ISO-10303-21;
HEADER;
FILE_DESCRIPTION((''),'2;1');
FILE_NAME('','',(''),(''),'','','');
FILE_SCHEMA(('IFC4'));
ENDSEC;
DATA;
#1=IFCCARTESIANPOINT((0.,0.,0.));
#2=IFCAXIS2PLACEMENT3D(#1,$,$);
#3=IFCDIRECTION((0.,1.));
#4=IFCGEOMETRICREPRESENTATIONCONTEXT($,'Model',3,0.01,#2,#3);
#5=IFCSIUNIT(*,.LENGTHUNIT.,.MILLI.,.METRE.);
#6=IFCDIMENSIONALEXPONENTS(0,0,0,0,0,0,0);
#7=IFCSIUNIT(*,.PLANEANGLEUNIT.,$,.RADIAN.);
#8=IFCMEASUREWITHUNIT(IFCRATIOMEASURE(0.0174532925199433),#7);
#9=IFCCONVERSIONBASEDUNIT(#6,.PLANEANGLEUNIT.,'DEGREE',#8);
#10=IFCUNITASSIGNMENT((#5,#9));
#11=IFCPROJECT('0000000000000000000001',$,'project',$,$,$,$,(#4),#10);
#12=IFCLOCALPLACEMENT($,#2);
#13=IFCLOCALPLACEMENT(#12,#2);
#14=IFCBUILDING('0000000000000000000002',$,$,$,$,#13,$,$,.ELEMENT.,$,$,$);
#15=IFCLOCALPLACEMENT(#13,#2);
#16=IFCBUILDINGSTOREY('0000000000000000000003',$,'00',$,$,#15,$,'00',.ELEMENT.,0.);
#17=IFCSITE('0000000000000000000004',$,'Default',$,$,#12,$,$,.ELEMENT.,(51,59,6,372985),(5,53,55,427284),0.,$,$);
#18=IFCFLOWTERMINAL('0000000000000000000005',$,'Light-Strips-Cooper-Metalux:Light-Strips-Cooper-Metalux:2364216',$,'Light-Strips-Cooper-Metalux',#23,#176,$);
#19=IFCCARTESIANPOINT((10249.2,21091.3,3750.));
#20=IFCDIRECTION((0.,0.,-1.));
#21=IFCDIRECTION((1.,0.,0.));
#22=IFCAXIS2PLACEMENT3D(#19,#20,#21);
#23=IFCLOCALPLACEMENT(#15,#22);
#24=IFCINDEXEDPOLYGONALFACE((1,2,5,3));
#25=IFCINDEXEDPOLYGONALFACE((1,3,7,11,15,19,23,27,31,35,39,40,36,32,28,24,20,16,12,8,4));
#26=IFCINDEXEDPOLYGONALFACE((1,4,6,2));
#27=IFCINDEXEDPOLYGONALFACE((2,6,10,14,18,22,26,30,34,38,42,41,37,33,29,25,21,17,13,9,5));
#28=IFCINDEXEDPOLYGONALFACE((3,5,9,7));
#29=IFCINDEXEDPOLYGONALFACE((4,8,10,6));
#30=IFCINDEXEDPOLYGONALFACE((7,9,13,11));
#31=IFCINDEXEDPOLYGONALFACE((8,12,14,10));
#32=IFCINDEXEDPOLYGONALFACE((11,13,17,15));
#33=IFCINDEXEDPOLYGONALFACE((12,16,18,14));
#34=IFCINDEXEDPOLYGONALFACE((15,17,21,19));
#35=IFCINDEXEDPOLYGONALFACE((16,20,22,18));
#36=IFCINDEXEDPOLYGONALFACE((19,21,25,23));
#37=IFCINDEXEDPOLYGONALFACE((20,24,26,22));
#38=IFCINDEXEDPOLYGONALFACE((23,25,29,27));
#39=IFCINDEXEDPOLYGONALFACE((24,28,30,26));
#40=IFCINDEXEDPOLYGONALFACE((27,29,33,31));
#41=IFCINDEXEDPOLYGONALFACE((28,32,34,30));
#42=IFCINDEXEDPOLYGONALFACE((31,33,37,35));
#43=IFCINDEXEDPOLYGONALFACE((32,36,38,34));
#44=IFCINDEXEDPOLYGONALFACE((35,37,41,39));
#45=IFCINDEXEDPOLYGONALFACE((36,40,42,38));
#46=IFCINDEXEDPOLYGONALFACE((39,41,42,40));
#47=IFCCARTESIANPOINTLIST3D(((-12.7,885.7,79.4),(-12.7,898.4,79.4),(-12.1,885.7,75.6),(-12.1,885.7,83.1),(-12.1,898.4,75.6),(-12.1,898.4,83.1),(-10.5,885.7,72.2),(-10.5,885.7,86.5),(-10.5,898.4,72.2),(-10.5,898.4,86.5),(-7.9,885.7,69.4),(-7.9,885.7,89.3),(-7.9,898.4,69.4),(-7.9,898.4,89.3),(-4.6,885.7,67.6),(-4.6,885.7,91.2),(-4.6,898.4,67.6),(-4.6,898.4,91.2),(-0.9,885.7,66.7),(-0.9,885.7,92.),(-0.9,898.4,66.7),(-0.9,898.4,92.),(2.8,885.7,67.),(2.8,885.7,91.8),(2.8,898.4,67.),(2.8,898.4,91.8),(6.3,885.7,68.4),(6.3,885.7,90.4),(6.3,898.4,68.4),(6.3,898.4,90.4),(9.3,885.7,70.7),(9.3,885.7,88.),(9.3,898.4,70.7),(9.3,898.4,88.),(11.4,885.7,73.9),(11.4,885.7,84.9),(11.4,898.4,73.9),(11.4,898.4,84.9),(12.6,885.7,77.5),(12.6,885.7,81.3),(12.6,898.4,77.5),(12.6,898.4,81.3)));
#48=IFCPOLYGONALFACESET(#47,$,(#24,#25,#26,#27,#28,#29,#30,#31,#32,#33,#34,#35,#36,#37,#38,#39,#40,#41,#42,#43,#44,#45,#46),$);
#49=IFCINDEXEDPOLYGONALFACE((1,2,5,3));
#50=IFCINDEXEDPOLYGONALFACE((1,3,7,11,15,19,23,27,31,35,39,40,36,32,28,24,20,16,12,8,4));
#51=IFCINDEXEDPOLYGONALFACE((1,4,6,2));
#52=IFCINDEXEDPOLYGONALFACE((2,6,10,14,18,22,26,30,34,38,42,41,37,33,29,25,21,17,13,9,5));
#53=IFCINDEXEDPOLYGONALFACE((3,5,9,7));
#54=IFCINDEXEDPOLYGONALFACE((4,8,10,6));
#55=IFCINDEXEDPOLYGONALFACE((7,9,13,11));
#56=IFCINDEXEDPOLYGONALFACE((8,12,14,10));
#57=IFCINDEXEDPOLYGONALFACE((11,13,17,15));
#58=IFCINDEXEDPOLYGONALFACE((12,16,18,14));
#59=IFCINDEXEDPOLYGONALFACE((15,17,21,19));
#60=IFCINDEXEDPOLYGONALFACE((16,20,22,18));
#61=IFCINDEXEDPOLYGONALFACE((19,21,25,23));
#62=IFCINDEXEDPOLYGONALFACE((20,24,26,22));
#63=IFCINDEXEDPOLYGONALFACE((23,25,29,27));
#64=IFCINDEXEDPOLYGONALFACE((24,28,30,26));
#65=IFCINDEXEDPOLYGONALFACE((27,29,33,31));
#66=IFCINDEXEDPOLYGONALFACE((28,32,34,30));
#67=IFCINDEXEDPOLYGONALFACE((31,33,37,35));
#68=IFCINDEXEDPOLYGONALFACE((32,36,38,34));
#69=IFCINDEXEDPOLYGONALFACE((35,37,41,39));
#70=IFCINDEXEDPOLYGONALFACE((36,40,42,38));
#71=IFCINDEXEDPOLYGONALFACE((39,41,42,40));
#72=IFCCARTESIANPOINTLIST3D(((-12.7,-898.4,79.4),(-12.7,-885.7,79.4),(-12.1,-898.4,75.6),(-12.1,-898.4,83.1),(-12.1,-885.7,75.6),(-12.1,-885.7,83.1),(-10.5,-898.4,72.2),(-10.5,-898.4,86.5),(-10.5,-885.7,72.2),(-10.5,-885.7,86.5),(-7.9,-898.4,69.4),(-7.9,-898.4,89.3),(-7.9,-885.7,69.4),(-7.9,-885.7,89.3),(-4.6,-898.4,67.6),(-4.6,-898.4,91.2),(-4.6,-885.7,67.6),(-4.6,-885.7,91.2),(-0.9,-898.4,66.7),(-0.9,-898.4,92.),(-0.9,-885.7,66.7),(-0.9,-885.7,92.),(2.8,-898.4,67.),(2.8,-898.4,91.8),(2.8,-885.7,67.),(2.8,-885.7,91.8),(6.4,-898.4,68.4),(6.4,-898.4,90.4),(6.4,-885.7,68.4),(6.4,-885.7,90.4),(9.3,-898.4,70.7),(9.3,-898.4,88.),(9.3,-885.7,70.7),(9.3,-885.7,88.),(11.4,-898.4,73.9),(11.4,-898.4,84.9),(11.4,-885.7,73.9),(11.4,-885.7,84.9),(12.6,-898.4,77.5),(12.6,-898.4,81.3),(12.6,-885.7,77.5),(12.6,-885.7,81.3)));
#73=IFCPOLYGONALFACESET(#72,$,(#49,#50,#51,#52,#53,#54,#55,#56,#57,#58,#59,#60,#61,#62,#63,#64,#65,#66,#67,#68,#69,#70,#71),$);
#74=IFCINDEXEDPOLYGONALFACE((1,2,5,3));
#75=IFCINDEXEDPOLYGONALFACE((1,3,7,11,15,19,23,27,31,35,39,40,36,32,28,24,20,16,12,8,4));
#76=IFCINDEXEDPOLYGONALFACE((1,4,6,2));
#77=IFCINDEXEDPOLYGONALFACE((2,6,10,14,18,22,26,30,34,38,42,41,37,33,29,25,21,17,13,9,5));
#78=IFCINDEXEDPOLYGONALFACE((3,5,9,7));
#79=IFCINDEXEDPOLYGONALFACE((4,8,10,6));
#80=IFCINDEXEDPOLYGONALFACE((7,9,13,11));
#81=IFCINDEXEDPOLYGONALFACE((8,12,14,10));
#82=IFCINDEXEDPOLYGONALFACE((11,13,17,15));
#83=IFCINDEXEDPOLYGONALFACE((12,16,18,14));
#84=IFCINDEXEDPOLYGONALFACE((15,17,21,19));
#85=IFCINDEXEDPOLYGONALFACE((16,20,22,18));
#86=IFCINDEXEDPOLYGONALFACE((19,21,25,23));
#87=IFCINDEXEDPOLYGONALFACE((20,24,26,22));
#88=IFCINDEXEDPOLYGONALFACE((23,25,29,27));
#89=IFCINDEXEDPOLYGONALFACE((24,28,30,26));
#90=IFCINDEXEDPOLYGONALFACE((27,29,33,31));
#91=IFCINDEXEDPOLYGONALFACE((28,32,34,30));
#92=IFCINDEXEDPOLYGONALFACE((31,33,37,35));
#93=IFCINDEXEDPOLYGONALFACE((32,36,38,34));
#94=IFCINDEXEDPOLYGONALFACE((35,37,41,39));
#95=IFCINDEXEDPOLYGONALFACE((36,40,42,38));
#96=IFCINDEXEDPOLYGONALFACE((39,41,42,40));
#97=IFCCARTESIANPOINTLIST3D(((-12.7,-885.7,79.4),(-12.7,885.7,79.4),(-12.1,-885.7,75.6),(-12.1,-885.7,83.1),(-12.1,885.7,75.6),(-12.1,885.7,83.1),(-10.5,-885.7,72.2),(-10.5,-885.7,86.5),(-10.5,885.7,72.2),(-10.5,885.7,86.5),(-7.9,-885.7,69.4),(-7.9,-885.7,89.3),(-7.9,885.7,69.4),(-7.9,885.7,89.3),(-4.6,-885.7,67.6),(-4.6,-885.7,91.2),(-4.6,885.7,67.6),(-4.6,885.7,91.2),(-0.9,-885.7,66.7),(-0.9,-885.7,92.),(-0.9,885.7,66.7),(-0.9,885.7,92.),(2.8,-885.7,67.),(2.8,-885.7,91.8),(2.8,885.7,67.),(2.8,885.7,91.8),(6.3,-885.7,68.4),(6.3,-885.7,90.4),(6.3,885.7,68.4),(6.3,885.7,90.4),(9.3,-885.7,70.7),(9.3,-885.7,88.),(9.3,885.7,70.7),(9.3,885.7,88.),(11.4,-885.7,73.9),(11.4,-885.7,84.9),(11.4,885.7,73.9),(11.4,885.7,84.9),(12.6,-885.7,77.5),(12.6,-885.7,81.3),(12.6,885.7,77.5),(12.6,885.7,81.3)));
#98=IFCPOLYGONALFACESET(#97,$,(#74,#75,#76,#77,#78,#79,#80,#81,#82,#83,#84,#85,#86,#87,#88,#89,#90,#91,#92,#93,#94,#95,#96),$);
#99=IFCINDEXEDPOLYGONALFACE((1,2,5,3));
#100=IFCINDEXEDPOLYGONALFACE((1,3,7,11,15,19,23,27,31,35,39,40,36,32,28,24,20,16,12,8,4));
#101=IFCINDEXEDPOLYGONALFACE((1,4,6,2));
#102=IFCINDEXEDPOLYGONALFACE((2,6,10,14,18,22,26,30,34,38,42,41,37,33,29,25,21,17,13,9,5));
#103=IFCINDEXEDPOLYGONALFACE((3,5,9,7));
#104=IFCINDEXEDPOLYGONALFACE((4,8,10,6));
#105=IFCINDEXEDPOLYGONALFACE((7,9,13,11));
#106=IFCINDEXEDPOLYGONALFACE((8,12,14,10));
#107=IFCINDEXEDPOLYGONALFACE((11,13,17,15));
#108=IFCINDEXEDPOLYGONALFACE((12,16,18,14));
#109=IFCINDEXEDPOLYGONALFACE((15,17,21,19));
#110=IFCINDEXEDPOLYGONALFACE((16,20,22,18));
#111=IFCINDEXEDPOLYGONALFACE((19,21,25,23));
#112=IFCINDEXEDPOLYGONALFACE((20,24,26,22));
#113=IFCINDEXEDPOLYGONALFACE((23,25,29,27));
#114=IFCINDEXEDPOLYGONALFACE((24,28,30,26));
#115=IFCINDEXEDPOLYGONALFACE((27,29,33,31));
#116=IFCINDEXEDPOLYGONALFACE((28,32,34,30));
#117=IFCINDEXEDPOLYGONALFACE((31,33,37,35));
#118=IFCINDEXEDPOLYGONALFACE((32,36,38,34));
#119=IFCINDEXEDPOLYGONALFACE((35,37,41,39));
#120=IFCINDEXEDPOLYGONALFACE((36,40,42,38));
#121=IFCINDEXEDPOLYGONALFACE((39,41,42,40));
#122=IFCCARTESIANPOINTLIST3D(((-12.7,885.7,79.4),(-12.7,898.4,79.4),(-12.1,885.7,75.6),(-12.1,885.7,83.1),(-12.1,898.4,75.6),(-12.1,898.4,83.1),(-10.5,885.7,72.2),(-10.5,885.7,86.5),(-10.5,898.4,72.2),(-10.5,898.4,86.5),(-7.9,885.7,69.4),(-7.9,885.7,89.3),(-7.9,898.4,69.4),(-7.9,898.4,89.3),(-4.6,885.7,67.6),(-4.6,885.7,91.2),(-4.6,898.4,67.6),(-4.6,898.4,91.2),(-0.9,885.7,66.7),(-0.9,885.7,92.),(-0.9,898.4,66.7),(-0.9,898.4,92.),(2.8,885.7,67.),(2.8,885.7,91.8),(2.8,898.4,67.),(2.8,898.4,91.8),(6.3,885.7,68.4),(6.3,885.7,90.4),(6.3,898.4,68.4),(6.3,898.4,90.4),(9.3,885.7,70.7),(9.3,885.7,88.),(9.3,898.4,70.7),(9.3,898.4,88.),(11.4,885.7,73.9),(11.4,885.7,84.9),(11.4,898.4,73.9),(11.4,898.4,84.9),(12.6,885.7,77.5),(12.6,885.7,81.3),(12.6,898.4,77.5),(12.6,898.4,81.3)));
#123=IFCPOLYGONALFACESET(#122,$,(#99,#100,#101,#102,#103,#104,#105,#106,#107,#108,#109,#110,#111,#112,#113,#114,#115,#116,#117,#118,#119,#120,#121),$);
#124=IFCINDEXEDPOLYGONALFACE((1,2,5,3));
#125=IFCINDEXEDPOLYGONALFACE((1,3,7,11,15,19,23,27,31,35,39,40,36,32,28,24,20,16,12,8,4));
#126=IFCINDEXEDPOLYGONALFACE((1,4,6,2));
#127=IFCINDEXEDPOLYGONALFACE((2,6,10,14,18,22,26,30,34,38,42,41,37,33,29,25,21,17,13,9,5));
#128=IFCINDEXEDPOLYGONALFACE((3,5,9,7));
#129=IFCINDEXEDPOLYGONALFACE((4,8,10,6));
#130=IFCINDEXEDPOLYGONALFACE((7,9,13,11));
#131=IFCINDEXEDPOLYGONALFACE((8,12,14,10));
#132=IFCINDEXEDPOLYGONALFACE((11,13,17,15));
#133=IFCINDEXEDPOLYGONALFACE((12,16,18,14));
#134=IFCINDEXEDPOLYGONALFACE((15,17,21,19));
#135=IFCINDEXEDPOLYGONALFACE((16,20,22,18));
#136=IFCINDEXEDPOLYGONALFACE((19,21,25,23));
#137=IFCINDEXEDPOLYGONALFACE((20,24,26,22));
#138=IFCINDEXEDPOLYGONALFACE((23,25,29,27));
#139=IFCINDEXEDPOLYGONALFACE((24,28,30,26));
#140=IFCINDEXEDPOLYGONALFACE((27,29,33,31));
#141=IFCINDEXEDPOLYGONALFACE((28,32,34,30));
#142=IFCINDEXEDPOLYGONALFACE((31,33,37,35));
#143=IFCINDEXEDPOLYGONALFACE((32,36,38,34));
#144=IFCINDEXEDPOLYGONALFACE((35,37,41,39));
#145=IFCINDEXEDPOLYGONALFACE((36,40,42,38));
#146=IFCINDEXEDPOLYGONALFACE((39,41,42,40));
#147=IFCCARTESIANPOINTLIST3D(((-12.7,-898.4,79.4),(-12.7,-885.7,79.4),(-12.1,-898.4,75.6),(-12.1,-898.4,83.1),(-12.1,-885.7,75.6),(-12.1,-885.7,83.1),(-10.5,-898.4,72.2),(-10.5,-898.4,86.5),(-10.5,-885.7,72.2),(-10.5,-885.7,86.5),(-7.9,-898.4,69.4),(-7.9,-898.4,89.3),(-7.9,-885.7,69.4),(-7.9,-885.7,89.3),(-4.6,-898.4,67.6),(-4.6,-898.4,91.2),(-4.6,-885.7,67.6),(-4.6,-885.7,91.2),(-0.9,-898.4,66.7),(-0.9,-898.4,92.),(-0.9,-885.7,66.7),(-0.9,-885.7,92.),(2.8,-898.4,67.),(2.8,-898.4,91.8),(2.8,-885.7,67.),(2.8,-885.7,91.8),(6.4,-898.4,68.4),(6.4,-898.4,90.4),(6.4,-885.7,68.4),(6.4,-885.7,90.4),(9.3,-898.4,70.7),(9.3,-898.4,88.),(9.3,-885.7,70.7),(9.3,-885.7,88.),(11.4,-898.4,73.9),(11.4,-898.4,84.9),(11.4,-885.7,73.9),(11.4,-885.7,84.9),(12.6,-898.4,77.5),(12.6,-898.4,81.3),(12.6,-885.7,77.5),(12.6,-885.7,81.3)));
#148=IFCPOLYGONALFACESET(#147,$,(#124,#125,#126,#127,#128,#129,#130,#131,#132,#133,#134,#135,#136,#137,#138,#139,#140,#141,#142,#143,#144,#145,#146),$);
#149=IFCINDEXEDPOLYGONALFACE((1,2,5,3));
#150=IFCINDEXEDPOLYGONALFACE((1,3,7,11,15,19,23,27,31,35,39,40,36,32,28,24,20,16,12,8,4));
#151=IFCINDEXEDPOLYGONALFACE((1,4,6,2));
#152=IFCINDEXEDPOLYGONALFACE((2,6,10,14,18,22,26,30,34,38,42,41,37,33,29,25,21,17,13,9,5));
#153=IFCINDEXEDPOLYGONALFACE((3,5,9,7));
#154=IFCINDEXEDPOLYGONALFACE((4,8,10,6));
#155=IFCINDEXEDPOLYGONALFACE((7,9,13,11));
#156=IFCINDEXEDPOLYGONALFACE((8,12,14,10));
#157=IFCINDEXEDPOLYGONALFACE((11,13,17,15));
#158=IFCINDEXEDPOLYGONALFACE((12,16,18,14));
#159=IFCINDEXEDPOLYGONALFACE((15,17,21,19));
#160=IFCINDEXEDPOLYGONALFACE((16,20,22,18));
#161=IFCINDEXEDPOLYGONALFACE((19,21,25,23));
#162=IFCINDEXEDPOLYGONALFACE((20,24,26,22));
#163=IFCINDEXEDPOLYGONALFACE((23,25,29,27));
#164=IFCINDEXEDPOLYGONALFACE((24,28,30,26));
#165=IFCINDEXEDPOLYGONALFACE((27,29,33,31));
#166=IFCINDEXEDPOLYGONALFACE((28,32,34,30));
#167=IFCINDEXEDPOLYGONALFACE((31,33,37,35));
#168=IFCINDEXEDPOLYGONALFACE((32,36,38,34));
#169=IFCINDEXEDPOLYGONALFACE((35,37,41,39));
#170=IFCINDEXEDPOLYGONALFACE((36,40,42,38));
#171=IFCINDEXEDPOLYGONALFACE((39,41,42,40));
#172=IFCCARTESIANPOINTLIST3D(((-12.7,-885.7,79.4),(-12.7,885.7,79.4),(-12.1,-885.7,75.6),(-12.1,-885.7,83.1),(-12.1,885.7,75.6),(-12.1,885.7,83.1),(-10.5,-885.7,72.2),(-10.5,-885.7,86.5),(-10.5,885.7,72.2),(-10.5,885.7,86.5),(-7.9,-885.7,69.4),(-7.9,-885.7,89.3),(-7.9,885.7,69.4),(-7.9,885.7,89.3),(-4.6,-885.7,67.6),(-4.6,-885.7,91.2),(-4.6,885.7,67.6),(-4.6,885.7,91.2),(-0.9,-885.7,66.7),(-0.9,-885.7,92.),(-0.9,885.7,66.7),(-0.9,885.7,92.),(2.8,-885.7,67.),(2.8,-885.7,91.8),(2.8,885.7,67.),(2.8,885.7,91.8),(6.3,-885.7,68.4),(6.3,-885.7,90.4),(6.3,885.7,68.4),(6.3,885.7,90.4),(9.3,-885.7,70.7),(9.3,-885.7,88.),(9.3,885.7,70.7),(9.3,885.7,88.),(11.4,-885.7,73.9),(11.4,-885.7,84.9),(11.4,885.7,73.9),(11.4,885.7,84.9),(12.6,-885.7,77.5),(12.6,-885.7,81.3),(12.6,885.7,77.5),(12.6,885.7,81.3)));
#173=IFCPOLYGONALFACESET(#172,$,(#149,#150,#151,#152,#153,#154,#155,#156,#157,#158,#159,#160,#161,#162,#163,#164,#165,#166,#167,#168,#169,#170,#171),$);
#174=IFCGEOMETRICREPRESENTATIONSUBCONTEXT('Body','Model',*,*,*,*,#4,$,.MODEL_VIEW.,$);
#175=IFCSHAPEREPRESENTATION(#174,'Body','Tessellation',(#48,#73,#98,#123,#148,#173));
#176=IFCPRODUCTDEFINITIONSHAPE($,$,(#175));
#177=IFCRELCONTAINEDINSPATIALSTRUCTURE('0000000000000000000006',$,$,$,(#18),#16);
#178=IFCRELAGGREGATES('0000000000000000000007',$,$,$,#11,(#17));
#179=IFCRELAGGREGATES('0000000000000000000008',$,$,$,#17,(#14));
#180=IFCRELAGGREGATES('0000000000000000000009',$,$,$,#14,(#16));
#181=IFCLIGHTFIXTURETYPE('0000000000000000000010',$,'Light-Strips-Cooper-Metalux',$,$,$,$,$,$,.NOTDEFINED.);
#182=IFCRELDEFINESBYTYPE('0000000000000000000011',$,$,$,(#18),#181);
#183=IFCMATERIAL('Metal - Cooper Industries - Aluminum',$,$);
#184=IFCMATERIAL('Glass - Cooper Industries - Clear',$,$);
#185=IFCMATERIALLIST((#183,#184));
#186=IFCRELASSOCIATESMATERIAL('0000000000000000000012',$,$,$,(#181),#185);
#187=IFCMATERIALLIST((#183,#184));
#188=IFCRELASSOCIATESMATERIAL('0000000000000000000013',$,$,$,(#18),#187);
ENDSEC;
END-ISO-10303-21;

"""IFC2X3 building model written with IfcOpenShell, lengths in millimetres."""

from ifc_helpers import new_model, entity, si_unit, converted_unit, direction, frame, frame_2d, origin, place, context, subcontext, project, spatial, circle, extrude, source, transform, mapped, material, material_list, type_object, type_shapes, element, save


model = new_model("IFC2X3")

# Units and contexts
model_context = context("Model", 3, precision=0.01, world=origin(), true_north=direction((0.0, 1.0)))
body_context = subcontext(model_context, "Body", "Model", "MODEL_VIEW")
ifc_project = project(units=[si_unit("LENGTHUNIT", "METRE", prefix="MILLI"), converted_unit("PLANEANGLEUNIT", "DEGREE", entity("IfcRatioMeasure", 0.0174532925199433), si_unit("PLANEANGLEUNIT", "RADIAN"), dimensions=[0, 0, 0, 0, 0, 0, 0])], contexts=[model_context])

# Site, building, storey
site_placement = place(None, origin())
site = spatial("IfcSite", under=ifc_project, at=site_placement, Name="Default", CompositionType="ELEMENT", RefLatitude=(51, 59, 6, 372985), RefLongitude=(5, 53, 55, 427284), RefElevation=0.0)
building_placement = place(site_placement, origin())
building = spatial("IfcBuilding", under=site, at=building_placement, CompositionType="ELEMENT")
storey_placement = place(building_placement, origin())
storey = spatial("IfcBuildingStorey", under=building, at=storey_placement, Name="00", LongName="00", CompositionType="ELEMENT", Elevation=0.0)

# Flow terminal
ifc_material_1 = material(Name="Metal - Cooper Industries - Aluminum")
ifc_material_2 = material(Name="Glass - Cooper Industries - Clear")
ifc_material_list_1 = material_list([ifc_material_1, ifc_material_2])
ifc_material_list_2 = material_list([ifc_material_1, ifc_material_2])
light_fixture_type_1 = type_object("IfcLightFixtureType", Name="Light-Strips-Cooper-Metalux", PredefinedType="NOTDEFINED", material=ifc_material_list_2)
shared_shape_1 = source(origin(), body_context, "Body", "SweptSolid", [
    extrude(circle(Radius=12.7, at=frame_2d((0.0, 0.0), x_axis=(1.0, 0.0))), frame((0.0, 885.7, 79.4), z_axis=(0.0, 1.0, 0.0), x_axis=(-1.0, 0.0, 0.0)), (0.0, 0.0, 1.0), 12.7),
    extrude(circle(Radius=12.7, at=frame_2d((0.0, 0.0), x_axis=(1.0, 0.0))), frame((0.0, -898.4, 79.4), z_axis=(0.0, 1.0, 0.0), x_axis=(-1.0, 0.0, 0.0)), (0.0, 0.0, 1.0), 12.7),
    extrude(circle(Radius=12.7, at=frame_2d((0.0, 0.0), x_axis=(1.0, 0.0))), frame((0.0, -885.7, 79.4), z_axis=(0.0, 1.0, 0.0), x_axis=(-1.0, 0.0, 0.0)), (0.0, 0.0, 1.0), 1771.4),
    extrude(circle(Radius=12.7, at=frame_2d((0.0, 0.0), x_axis=(1.0, 0.0))), frame((0.0, 885.7, 79.4), z_axis=(0.0, 1.0, 0.0), x_axis=(-1.0, 0.0, 0.0)), (0.0, 0.0, 1.0), 12.7),
    extrude(circle(Radius=12.7, at=frame_2d((0.0, 0.0), x_axis=(1.0, 0.0))), frame((0.0, -898.4, 79.4), z_axis=(0.0, 1.0, 0.0), x_axis=(-1.0, 0.0, 0.0)), (0.0, 0.0, 1.0), 12.7),
    extrude(circle(Radius=12.7, at=frame_2d((0.0, 0.0), x_axis=(1.0, 0.0))), frame((0.0, -885.7, 79.4), z_axis=(0.0, 1.0, 0.0), x_axis=(-1.0, 0.0, 0.0)), (0.0, 0.0, 1.0), 1771.4),
])
type_shapes(light_fixture_type_1, [shared_shape_1])
flow_terminal_1_placement = place(storey_placement, frame((10249.2, 21091.3, 3750.0), z_axis=(0.0, 0.0, -1.0), x_axis=(1.0, 0.0, 0.0)))
element("IfcFlowTerminal", 1, at=flow_terminal_1_placement, inside=storey, type_object=light_fixture_type_1, material=ifc_material_list_1, Name="Light-Strips-Cooper-Metalux:Light-Strips-Cooper-Metalux:2364216", ObjectType="Light-Strips-Cooper-Metalux", context=body_context, shape_type="MappedRepresentation", body=[
    mapped(shared_shape_1, transform((0.0, 0.0, 0.0), scale=1.0)),
])

save(model, "model.ifc")
